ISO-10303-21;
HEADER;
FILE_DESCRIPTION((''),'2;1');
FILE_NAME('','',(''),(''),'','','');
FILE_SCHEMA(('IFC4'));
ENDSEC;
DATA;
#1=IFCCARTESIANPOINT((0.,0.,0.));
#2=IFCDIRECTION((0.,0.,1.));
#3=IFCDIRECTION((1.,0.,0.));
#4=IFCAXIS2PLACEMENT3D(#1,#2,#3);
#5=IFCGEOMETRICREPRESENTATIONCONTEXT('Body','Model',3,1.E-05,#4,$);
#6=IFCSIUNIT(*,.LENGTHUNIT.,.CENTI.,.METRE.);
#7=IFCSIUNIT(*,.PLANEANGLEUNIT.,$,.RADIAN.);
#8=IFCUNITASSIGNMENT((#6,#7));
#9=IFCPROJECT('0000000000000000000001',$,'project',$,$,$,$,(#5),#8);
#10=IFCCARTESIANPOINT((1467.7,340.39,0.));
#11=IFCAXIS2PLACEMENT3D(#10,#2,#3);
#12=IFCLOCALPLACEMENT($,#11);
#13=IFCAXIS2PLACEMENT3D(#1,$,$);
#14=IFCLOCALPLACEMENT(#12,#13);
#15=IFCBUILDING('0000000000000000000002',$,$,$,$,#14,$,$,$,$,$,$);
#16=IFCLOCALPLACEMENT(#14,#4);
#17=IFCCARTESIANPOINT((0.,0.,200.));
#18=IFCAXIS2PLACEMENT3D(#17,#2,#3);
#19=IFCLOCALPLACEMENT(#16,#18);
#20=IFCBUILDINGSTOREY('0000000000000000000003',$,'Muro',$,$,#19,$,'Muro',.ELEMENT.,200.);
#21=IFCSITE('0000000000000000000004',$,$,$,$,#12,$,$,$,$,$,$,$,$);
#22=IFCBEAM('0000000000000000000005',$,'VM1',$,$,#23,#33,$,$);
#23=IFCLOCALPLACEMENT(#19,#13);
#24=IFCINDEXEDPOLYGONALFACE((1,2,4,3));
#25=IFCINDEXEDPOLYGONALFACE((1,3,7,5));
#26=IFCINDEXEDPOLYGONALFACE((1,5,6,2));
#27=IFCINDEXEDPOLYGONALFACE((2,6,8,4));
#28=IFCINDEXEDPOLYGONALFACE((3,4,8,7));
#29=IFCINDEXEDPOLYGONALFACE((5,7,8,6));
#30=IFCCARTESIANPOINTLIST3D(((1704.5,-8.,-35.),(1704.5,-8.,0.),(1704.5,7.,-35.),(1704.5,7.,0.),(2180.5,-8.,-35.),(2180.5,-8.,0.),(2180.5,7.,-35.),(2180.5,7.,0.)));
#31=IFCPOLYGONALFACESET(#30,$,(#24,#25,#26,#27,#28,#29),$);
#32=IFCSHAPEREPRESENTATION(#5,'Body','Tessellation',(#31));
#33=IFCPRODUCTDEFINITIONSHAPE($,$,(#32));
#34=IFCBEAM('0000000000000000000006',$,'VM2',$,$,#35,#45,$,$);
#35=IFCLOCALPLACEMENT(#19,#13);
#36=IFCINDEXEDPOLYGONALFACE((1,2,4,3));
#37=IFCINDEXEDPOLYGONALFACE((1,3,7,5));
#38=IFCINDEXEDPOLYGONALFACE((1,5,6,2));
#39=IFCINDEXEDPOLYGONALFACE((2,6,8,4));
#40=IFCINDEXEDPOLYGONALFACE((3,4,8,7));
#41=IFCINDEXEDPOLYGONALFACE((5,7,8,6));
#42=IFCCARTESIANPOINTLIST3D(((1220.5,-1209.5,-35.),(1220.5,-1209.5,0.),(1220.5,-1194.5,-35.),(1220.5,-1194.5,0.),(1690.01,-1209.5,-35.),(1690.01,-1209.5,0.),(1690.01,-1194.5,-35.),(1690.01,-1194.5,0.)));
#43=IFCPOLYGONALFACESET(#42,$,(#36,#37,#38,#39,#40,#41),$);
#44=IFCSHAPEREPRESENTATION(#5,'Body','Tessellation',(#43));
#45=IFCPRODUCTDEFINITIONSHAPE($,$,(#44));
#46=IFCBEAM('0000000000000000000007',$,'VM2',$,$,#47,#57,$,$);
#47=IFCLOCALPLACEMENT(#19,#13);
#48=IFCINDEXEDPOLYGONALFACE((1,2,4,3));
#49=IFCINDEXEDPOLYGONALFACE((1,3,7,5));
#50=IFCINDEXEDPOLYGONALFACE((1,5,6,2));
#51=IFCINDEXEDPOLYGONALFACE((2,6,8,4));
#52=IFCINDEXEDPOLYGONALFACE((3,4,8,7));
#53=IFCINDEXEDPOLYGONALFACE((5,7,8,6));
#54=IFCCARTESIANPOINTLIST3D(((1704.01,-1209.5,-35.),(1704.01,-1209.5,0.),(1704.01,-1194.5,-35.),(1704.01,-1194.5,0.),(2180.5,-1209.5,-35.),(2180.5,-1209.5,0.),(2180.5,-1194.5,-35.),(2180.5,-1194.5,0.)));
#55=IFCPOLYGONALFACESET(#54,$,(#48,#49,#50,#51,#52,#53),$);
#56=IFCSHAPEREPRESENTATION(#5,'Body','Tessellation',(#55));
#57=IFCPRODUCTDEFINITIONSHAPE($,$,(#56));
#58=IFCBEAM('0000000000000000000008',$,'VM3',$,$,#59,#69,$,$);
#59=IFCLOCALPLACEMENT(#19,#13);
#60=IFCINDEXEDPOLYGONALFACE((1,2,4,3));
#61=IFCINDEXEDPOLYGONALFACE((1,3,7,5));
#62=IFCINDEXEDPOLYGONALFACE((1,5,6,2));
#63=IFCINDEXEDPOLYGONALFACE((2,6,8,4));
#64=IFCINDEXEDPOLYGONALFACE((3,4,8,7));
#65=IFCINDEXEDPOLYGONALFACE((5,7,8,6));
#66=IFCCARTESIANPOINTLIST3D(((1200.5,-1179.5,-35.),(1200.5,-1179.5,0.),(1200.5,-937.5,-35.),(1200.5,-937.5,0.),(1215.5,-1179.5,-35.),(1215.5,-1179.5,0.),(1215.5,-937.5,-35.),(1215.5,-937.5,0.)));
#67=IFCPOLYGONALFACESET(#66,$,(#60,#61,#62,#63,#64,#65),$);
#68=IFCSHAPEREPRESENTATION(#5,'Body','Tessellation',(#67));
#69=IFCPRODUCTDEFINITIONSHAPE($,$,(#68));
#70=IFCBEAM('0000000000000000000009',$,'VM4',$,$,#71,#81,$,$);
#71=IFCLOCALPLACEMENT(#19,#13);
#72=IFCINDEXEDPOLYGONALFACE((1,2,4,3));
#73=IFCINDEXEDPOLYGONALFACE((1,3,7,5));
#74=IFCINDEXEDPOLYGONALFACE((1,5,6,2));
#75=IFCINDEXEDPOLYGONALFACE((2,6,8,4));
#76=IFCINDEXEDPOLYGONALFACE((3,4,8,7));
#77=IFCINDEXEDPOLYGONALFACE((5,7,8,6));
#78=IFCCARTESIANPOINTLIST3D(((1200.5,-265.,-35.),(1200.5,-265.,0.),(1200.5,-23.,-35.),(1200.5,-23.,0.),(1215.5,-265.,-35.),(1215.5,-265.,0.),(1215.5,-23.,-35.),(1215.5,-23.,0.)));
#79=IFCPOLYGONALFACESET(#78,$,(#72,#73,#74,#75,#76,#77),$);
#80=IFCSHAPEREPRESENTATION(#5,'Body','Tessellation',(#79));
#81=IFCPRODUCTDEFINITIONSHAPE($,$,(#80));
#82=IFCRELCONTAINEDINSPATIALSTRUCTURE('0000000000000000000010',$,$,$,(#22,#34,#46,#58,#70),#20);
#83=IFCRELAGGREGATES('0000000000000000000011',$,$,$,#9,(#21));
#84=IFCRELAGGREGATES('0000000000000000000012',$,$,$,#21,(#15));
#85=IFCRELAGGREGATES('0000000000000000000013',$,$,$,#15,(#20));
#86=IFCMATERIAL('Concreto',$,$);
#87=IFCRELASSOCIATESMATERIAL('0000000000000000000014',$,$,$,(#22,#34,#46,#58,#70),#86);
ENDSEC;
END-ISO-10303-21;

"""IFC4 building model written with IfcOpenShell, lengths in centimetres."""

from ifc_helpers import new_model, si_unit, frame, origin, origin_with_axes, origin_2d_with_axis, place, context, project, spatial, rectangle, extrude, material, element, save


model = new_model("IFC4")

# Units and contexts
model_context = context("Model", 3, precision=1e-05, world=origin_with_axes(), identifier="Body")
ifc_project = project(units=[si_unit("LENGTHUNIT", "METRE", prefix="CENTI"), si_unit("PLANEANGLEUNIT", "RADIAN")], contexts=[model_context])

# Site, building, storey
site_placement = place(None, frame((1467.7, 340.39, 0.0), z_axis=(0.0, 0.0, 1.0), x_axis=(1.0, 0.0, 0.0)))
site = spatial("IfcSite", under=ifc_project, at=site_placement)
building_placement = place(site_placement, origin())
building = spatial("IfcBuilding", under=site, at=building_placement)
placement = place(building_placement, origin_with_axes())
storey_placement = place(placement, frame((0.0, 0.0, 200.0), z_axis=(0.0, 0.0, 1.0), x_axis=(1.0, 0.0, 0.0)))
storey = spatial("IfcBuildingStorey", under=building, at=storey_placement, Name="Muro", LongName="Muro", CompositionType="ELEMENT", Elevation=200.0)

# Shared definitions
ifc_material = material(Name="Concreto")

# Beams
beam_1_placement = place(storey_placement, frame((1942.5, -0.5, 0.0), z_axis=(0.0, 0.0, 1.0), x_axis=(1.0, 0.0, 0.0)))
element("IfcBeam", 1, at=beam_1_placement, inside=storey, material=ifc_material, Name="VM1", context=model_context, shape_type="SolidModel", body=[
    extrude(rectangle(XDim=15.0, YDim=35.0, at=origin_2d_with_axis()), frame((-238.0, 0.0, -17.5), z_axis=(1.0, 0.0, 0.0), x_axis=(0.0, 1.0, 0.0)), (0.0, 0.0, 1.0), 476.0),
])
beam_2_placement = place(storey_placement, frame((1455.26, -1202.0, 0.0), z_axis=(0.0, 0.0, 1.0), x_axis=(1.0, 0.0, 0.0)))
element("IfcBeam", 2, at=beam_2_placement, inside=storey, material=ifc_material, Name="VM2", context=model_context, shape_type="SolidModel", body=[
    extrude(rectangle(XDim=15.0, YDim=35.0, at=origin_2d_with_axis()), frame((-234.75, 0.0, -17.5), z_axis=(1.0, 0.0, 0.0), x_axis=(0.0, -1.0, 0.0)), (0.0, 0.0, 1.0), 469.51),
])
beam_3_placement = place(storey_placement, frame((1942.26, -1202.0, 0.0), z_axis=(0.0, 0.0, 1.0), x_axis=(1.0, 0.0, 0.0)))
element("IfcBeam", 3, at=beam_3_placement, inside=storey, material=ifc_material, Name="VM2", context=model_context, shape_type="SolidModel", body=[
    extrude(rectangle(XDim=15.0, YDim=35.0, at=origin_2d_with_axis()), frame((-238.25, 0.0, -17.5), z_axis=(1.0, 0.0, 0.0), x_axis=(0.0, -1.0, 0.0)), (0.0, 0.0, 1.0), 476.49),
])
for number, where, z_axis, x_axis, name in (
    (4, (1208.0, -1058.5, 0.0), (0.0, 0.0, 1.0), (1.0, 0.0, 0.0), "VM3"),
    (5, (1208.0, -144.0, 0.0), (0.0, 0.0, 1.0), (1.0, 0.0, 0.0), "VM4"),
):
    element("IfcBeam", number, at=place(storey_placement, frame(where, z_axis=z_axis, x_axis=x_axis)), inside=storey, material=ifc_material, Name=name, context=model_context, shape_type="SolidModel", body=[
        extrude(rectangle(XDim=15.0, YDim=35.0, at=origin_2d_with_axis()), frame((0.0, -121.0, -17.5), z_axis=(0.0, 1.0, 0.0), x_axis=(1.0, 0.0, 0.0)), (0.0, 0.0, 1.0), 242.0),
    ])

save(model, "model.ifc")
